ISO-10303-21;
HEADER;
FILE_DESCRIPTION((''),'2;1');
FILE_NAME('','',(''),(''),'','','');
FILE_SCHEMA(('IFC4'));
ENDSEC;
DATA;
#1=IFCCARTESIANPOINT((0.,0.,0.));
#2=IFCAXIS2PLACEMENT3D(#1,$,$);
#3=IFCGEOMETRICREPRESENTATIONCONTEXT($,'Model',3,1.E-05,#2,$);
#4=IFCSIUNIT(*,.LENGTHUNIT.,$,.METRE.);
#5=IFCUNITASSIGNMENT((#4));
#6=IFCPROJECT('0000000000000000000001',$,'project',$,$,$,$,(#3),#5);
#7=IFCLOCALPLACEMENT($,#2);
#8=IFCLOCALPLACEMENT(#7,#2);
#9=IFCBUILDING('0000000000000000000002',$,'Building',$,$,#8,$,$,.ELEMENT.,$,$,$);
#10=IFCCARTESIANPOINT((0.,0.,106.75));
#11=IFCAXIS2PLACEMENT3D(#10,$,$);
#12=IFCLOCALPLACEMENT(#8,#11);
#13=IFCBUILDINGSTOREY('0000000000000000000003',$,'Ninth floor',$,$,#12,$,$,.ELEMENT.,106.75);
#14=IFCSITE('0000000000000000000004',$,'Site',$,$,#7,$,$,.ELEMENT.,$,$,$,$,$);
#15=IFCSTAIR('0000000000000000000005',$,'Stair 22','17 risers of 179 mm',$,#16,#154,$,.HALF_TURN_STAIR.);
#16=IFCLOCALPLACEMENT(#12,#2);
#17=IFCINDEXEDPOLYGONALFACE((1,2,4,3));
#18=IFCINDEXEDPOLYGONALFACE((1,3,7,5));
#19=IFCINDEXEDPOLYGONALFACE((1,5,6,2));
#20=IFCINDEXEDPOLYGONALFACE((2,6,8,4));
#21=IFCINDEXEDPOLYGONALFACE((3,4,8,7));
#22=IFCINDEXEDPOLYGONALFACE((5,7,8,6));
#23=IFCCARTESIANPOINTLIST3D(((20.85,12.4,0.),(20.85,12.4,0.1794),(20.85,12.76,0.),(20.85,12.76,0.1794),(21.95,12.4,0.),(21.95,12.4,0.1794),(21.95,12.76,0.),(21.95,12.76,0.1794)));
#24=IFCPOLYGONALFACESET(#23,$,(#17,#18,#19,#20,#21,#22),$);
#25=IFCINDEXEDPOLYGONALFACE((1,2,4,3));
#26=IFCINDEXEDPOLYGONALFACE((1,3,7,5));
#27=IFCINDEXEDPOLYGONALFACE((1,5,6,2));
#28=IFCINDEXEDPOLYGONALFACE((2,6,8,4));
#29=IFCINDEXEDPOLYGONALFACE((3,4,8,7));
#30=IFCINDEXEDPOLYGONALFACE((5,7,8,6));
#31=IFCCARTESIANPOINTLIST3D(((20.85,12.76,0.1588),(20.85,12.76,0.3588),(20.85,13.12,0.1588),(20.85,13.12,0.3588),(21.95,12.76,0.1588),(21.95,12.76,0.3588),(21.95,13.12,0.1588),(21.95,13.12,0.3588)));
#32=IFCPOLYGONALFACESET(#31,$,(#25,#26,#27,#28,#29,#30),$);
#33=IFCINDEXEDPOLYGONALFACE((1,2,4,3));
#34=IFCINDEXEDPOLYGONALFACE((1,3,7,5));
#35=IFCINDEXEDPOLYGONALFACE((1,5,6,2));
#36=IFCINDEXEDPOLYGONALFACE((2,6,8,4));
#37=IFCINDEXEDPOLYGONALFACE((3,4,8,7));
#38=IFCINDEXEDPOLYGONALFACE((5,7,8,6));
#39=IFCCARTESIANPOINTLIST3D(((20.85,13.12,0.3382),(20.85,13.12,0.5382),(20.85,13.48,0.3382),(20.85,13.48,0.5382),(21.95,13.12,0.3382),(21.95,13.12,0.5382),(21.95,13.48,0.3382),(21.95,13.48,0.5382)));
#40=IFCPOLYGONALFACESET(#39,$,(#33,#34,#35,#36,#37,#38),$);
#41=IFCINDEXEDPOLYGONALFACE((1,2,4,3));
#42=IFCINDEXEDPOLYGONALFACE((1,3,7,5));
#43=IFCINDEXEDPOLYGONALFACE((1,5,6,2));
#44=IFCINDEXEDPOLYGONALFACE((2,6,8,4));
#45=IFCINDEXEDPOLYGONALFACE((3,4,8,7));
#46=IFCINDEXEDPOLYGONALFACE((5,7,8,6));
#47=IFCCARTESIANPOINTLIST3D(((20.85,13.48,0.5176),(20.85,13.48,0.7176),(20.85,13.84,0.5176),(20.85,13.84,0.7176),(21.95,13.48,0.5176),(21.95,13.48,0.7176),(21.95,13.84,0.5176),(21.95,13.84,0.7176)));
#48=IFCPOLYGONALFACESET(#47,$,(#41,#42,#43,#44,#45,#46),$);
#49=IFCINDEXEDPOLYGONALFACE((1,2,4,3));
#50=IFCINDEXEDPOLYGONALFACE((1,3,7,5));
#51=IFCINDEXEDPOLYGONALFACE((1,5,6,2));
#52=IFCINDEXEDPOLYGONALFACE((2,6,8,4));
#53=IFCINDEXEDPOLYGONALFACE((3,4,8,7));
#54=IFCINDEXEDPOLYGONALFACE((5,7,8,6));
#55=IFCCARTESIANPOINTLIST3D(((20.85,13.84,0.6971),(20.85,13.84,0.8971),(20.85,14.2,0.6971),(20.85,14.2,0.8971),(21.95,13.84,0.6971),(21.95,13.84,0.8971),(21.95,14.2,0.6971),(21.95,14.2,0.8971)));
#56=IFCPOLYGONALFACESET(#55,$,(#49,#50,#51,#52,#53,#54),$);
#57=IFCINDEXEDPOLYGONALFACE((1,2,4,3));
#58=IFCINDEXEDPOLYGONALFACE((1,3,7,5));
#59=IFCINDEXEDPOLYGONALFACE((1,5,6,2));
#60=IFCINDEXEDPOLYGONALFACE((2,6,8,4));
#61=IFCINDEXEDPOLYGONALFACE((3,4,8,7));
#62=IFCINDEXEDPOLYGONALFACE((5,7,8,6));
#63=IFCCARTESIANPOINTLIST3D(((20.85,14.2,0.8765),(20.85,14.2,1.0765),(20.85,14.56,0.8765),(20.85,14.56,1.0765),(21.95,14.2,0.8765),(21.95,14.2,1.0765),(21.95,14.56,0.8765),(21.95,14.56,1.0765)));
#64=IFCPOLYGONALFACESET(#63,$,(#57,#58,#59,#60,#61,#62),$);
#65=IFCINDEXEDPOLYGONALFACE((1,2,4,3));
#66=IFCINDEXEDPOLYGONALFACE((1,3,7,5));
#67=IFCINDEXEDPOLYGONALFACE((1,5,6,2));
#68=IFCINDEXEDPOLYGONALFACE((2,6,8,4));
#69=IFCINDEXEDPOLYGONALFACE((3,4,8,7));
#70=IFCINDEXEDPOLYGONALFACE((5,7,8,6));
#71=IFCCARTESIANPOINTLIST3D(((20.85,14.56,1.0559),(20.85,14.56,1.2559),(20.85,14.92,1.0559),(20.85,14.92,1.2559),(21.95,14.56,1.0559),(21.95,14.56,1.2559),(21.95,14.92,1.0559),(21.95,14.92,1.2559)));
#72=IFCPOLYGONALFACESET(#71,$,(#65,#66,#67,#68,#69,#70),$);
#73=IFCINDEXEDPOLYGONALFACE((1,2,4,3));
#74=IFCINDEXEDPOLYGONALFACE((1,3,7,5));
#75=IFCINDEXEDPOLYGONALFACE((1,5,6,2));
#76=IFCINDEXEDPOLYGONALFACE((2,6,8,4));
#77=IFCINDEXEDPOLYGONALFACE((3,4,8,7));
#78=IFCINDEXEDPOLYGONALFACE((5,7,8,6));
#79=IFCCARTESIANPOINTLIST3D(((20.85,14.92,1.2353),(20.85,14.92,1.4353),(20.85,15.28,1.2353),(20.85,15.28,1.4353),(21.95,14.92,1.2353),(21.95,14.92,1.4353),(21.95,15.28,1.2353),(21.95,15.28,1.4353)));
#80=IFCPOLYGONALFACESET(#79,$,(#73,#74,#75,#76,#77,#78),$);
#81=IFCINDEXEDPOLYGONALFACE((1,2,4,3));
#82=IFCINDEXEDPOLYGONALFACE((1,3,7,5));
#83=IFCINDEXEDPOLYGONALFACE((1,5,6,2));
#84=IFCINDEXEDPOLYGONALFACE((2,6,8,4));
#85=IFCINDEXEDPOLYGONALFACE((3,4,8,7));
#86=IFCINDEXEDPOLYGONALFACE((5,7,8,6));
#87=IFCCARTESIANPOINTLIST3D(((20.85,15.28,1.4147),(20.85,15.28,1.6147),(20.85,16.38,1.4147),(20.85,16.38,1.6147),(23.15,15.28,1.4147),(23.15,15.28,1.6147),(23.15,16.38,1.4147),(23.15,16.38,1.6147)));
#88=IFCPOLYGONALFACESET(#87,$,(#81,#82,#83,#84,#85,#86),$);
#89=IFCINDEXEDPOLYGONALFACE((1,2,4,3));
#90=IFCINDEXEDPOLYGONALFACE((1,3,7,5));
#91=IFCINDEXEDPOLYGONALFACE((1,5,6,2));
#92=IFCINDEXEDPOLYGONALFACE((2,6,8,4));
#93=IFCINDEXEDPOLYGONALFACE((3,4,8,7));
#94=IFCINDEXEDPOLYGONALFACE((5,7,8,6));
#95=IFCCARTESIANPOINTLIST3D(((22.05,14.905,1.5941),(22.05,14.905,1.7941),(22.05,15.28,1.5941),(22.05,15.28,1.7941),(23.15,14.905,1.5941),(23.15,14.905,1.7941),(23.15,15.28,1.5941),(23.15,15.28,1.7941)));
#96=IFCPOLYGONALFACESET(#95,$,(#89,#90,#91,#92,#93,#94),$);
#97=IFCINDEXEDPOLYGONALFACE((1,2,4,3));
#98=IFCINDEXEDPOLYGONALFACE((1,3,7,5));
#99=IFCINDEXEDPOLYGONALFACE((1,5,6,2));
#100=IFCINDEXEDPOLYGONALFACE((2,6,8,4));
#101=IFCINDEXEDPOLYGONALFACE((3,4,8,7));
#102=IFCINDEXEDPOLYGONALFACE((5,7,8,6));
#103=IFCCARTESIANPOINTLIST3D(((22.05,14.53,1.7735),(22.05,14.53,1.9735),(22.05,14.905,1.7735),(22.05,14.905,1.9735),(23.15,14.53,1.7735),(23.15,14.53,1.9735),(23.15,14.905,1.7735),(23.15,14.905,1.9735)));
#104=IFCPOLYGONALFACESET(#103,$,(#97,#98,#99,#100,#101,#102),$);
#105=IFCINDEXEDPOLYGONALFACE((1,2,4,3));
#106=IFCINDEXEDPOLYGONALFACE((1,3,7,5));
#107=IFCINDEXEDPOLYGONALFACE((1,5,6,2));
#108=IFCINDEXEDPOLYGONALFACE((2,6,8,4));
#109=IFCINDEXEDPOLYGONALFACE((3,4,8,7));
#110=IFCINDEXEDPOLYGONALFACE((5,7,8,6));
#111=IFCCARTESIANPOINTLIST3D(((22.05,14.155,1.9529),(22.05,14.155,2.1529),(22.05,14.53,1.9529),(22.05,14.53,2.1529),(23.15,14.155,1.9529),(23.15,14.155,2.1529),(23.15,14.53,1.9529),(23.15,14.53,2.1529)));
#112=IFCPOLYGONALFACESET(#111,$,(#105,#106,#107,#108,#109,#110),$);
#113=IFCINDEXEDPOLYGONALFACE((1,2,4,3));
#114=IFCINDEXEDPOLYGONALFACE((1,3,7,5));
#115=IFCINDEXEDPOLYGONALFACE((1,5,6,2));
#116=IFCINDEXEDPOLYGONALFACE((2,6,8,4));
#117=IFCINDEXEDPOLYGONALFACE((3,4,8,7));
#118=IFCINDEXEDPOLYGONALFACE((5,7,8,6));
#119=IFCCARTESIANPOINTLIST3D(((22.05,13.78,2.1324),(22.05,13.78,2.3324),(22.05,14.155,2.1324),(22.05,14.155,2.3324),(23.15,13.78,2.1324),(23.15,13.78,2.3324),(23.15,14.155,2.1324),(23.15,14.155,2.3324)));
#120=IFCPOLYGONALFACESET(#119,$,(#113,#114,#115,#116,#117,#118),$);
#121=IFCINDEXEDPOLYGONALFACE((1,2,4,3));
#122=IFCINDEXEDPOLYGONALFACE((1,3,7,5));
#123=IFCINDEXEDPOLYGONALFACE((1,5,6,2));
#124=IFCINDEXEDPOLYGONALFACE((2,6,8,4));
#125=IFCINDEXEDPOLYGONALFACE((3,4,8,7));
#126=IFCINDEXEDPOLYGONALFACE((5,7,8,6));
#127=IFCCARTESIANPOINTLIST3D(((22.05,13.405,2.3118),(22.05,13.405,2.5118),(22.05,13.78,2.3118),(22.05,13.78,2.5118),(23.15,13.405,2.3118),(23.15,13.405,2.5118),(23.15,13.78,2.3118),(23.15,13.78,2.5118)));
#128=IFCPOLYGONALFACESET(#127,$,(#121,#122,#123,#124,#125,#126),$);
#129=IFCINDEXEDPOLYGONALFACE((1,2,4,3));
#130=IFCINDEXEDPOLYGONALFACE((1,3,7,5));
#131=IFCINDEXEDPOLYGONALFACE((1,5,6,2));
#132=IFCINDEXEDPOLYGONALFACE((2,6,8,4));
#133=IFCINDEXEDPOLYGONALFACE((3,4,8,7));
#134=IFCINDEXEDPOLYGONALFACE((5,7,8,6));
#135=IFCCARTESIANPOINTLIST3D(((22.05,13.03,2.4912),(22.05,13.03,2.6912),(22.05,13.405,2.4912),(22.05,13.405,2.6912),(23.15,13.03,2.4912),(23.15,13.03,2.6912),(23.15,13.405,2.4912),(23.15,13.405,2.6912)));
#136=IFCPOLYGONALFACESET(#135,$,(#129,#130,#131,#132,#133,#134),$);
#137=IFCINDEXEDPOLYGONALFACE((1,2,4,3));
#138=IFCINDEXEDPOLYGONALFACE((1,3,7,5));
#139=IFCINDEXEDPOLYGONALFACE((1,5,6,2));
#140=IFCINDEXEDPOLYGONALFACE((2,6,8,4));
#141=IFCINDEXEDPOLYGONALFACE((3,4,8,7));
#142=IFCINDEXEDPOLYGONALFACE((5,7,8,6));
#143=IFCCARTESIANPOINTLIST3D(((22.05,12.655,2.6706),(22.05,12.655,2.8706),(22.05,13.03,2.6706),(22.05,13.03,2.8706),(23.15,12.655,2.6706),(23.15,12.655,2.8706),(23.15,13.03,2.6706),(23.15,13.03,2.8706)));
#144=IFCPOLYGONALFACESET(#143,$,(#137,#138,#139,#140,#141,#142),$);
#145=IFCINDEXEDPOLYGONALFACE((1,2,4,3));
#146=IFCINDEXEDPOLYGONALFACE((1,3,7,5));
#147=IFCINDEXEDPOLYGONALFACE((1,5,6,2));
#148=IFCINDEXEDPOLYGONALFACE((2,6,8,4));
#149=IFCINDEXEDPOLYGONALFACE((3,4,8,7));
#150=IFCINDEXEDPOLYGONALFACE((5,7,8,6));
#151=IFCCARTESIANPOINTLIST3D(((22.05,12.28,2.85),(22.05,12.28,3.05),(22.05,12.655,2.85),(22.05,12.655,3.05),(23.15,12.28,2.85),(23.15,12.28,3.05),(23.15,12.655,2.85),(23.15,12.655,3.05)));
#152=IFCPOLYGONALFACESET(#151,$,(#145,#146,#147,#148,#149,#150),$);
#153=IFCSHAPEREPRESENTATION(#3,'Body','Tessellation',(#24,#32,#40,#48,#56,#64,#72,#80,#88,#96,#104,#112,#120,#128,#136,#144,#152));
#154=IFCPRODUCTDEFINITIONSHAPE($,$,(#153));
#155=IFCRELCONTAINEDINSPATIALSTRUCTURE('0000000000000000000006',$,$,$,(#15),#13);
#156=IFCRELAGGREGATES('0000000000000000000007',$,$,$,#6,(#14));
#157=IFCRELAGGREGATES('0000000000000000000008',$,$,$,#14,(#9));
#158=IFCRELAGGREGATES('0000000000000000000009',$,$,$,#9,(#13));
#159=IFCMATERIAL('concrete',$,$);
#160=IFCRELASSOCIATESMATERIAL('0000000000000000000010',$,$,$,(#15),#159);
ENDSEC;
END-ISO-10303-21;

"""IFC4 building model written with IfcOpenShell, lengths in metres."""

from ifc_helpers import new_model, si_unit, frame, origin, place, context, project, spatial, polyline, outline, extrude, material, element, save


model = new_model("IFC4")

# Units and contexts
model_context = context("Model", 3, precision=1e-05, world=origin())
ifc_project = project(units=[si_unit("LENGTHUNIT", "METRE")], contexts=[model_context])

# Site, building, storey
site_placement = place(None, origin())
site = spatial("IfcSite", under=ifc_project, at=site_placement, Name="Site", CompositionType="ELEMENT")
building_placement = place(site_placement, origin())
building = spatial("IfcBuilding", under=site, at=building_placement, Name="Building", CompositionType="ELEMENT")
storey_placement = place(building_placement, frame((0.0, 0.0, 106.75)))
storey = spatial("IfcBuildingStorey", under=building, at=storey_placement, Name="Ninth floor", CompositionType="ELEMENT", Elevation=106.75)

# Shared definitions
ifc_material = material(Name="concrete")

# Stair
stair_1_placement = place(storey_placement, frame((21.4, 12.4, 0.0), z_axis=(0.0, 0.0, 1.0), x_axis=(0.0, 1.0, 0.0)))
element("IfcStair", 1, at=stair_1_placement, inside=storey, material=ifc_material, Name="Stair 22", Description="17 risers of 179 mm", PredefinedType="HALF_TURN_STAIR", context=model_context, shape_type="SweptSolid", body=[
    extrude(outline(polyline([(0.0, -0.55), (0.36, -0.55), (0.36, 0.55), (0.0, 0.55), (0.0, -0.55)])), origin(), (0.0, 0.0, 1.0), 0.1794),
    extrude(outline(polyline([(0.36, -0.55), (0.72, -0.55), (0.72, 0.55), (0.36, 0.55), (0.36, -0.55)])), frame((0.0, 0.0, 0.1588)), (0.0, 0.0, 1.0), 0.2),
    extrude(outline(polyline([(0.72, -0.55), (1.08, -0.55), (1.08, 0.55), (0.72, 0.55), (0.72, -0.55)])), frame((0.0, 0.0, 0.3382)), (0.0, 0.0, 1.0), 0.2),
    extrude(outline(polyline([(1.08, -0.55), (1.44, -0.55), (1.44, 0.55), (1.08, 0.55), (1.08, -0.55)])), frame((0.0, 0.0, 0.5176)), (0.0, 0.0, 1.0), 0.2),
    extrude(outline(polyline([(1.44, -0.55), (1.8, -0.55), (1.8, 0.55), (1.44, 0.55), (1.44, -0.55)])), frame((0.0, 0.0, 0.6971)), (0.0, 0.0, 1.0), 0.2),
    extrude(outline(polyline([(1.8, -0.55), (2.16, -0.55), (2.16, 0.55), (1.8, 0.55), (1.8, -0.55)])), frame((0.0, 0.0, 0.8765)), (0.0, 0.0, 1.0), 0.2),
    extrude(outline(polyline([(2.16, -0.55), (2.52, -0.55), (2.52, 0.55), (2.16, 0.55), (2.16, -0.55)])), frame((0.0, 0.0, 1.0559)), (0.0, 0.0, 1.0), 0.2),
    extrude(outline(polyline([(2.52, -0.55), (2.88, -0.55), (2.88, 0.55), (2.52, 0.55), (2.52, -0.55)])), frame((0.0, 0.0, 1.2353)), (0.0, 0.0, 1.0), 0.2),
    extrude(outline(polyline([(2.88, -1.75), (3.98, -1.75), (3.98, 0.55), (2.88, 0.55), (2.88, -1.75)])), frame((0.0, 0.0, 1.4147)), (0.0, 0.0, 1.0), 0.2),
    extrude(outline(polyline([(2.505, -1.75), (2.88, -1.75), (2.88, -0.65), (2.505, -0.65), (2.505, -1.75)])), frame((0.0, 0.0, 1.5941)), (0.0, 0.0, 1.0), 0.2),
    extrude(outline(polyline([(2.13, -1.75), (2.505, -1.75), (2.505, -0.65), (2.13, -0.65), (2.13, -1.75)])), frame((0.0, 0.0, 1.7735)), (0.0, 0.0, 1.0), 0.2),
    extrude(outline(polyline([(1.755, -1.75), (2.13, -1.75), (2.13, -0.65), (1.755, -0.65), (1.755, -1.75)])), frame((0.0, 0.0, 1.9529)), (0.0, 0.0, 1.0), 0.2),
    extrude(outline(polyline([(1.38, -1.75), (1.755, -1.75), (1.755, -0.65), (1.38, -0.65), (1.38, -1.75)])), frame((0.0, 0.0, 2.1324)), (0.0, 0.0, 1.0), 0.2),
    extrude(outline(polyline([(1.005, -1.75), (1.38, -1.75), (1.38, -0.65), (1.005, -0.65), (1.005, -1.75)])), frame((0.0, 0.0, 2.3118)), (0.0, 0.0, 1.0), 0.2),
    extrude(outline(polyline([(0.63, -1.75), (1.005, -1.75), (1.005, -0.65), (0.63, -0.65), (0.63, -1.75)])), frame((0.0, 0.0, 2.4912)), (0.0, 0.0, 1.0), 0.2),
    extrude(outline(polyline([(0.255, -1.75), (0.63, -1.75), (0.63, -0.65), (0.255, -0.65), (0.255, -1.75)])), frame((0.0, 0.0, 2.6706)), (0.0, 0.0, 1.0), 0.2),
    extrude(outline(polyline([(-0.12, -1.75), (0.255, -1.75), (0.255, -0.65), (-0.12, -0.65), (-0.12, -1.75)])), frame((0.0, 0.0, 2.85)), (0.0, 0.0, 1.0), 0.2),
])

save(model, "model.ifc")
